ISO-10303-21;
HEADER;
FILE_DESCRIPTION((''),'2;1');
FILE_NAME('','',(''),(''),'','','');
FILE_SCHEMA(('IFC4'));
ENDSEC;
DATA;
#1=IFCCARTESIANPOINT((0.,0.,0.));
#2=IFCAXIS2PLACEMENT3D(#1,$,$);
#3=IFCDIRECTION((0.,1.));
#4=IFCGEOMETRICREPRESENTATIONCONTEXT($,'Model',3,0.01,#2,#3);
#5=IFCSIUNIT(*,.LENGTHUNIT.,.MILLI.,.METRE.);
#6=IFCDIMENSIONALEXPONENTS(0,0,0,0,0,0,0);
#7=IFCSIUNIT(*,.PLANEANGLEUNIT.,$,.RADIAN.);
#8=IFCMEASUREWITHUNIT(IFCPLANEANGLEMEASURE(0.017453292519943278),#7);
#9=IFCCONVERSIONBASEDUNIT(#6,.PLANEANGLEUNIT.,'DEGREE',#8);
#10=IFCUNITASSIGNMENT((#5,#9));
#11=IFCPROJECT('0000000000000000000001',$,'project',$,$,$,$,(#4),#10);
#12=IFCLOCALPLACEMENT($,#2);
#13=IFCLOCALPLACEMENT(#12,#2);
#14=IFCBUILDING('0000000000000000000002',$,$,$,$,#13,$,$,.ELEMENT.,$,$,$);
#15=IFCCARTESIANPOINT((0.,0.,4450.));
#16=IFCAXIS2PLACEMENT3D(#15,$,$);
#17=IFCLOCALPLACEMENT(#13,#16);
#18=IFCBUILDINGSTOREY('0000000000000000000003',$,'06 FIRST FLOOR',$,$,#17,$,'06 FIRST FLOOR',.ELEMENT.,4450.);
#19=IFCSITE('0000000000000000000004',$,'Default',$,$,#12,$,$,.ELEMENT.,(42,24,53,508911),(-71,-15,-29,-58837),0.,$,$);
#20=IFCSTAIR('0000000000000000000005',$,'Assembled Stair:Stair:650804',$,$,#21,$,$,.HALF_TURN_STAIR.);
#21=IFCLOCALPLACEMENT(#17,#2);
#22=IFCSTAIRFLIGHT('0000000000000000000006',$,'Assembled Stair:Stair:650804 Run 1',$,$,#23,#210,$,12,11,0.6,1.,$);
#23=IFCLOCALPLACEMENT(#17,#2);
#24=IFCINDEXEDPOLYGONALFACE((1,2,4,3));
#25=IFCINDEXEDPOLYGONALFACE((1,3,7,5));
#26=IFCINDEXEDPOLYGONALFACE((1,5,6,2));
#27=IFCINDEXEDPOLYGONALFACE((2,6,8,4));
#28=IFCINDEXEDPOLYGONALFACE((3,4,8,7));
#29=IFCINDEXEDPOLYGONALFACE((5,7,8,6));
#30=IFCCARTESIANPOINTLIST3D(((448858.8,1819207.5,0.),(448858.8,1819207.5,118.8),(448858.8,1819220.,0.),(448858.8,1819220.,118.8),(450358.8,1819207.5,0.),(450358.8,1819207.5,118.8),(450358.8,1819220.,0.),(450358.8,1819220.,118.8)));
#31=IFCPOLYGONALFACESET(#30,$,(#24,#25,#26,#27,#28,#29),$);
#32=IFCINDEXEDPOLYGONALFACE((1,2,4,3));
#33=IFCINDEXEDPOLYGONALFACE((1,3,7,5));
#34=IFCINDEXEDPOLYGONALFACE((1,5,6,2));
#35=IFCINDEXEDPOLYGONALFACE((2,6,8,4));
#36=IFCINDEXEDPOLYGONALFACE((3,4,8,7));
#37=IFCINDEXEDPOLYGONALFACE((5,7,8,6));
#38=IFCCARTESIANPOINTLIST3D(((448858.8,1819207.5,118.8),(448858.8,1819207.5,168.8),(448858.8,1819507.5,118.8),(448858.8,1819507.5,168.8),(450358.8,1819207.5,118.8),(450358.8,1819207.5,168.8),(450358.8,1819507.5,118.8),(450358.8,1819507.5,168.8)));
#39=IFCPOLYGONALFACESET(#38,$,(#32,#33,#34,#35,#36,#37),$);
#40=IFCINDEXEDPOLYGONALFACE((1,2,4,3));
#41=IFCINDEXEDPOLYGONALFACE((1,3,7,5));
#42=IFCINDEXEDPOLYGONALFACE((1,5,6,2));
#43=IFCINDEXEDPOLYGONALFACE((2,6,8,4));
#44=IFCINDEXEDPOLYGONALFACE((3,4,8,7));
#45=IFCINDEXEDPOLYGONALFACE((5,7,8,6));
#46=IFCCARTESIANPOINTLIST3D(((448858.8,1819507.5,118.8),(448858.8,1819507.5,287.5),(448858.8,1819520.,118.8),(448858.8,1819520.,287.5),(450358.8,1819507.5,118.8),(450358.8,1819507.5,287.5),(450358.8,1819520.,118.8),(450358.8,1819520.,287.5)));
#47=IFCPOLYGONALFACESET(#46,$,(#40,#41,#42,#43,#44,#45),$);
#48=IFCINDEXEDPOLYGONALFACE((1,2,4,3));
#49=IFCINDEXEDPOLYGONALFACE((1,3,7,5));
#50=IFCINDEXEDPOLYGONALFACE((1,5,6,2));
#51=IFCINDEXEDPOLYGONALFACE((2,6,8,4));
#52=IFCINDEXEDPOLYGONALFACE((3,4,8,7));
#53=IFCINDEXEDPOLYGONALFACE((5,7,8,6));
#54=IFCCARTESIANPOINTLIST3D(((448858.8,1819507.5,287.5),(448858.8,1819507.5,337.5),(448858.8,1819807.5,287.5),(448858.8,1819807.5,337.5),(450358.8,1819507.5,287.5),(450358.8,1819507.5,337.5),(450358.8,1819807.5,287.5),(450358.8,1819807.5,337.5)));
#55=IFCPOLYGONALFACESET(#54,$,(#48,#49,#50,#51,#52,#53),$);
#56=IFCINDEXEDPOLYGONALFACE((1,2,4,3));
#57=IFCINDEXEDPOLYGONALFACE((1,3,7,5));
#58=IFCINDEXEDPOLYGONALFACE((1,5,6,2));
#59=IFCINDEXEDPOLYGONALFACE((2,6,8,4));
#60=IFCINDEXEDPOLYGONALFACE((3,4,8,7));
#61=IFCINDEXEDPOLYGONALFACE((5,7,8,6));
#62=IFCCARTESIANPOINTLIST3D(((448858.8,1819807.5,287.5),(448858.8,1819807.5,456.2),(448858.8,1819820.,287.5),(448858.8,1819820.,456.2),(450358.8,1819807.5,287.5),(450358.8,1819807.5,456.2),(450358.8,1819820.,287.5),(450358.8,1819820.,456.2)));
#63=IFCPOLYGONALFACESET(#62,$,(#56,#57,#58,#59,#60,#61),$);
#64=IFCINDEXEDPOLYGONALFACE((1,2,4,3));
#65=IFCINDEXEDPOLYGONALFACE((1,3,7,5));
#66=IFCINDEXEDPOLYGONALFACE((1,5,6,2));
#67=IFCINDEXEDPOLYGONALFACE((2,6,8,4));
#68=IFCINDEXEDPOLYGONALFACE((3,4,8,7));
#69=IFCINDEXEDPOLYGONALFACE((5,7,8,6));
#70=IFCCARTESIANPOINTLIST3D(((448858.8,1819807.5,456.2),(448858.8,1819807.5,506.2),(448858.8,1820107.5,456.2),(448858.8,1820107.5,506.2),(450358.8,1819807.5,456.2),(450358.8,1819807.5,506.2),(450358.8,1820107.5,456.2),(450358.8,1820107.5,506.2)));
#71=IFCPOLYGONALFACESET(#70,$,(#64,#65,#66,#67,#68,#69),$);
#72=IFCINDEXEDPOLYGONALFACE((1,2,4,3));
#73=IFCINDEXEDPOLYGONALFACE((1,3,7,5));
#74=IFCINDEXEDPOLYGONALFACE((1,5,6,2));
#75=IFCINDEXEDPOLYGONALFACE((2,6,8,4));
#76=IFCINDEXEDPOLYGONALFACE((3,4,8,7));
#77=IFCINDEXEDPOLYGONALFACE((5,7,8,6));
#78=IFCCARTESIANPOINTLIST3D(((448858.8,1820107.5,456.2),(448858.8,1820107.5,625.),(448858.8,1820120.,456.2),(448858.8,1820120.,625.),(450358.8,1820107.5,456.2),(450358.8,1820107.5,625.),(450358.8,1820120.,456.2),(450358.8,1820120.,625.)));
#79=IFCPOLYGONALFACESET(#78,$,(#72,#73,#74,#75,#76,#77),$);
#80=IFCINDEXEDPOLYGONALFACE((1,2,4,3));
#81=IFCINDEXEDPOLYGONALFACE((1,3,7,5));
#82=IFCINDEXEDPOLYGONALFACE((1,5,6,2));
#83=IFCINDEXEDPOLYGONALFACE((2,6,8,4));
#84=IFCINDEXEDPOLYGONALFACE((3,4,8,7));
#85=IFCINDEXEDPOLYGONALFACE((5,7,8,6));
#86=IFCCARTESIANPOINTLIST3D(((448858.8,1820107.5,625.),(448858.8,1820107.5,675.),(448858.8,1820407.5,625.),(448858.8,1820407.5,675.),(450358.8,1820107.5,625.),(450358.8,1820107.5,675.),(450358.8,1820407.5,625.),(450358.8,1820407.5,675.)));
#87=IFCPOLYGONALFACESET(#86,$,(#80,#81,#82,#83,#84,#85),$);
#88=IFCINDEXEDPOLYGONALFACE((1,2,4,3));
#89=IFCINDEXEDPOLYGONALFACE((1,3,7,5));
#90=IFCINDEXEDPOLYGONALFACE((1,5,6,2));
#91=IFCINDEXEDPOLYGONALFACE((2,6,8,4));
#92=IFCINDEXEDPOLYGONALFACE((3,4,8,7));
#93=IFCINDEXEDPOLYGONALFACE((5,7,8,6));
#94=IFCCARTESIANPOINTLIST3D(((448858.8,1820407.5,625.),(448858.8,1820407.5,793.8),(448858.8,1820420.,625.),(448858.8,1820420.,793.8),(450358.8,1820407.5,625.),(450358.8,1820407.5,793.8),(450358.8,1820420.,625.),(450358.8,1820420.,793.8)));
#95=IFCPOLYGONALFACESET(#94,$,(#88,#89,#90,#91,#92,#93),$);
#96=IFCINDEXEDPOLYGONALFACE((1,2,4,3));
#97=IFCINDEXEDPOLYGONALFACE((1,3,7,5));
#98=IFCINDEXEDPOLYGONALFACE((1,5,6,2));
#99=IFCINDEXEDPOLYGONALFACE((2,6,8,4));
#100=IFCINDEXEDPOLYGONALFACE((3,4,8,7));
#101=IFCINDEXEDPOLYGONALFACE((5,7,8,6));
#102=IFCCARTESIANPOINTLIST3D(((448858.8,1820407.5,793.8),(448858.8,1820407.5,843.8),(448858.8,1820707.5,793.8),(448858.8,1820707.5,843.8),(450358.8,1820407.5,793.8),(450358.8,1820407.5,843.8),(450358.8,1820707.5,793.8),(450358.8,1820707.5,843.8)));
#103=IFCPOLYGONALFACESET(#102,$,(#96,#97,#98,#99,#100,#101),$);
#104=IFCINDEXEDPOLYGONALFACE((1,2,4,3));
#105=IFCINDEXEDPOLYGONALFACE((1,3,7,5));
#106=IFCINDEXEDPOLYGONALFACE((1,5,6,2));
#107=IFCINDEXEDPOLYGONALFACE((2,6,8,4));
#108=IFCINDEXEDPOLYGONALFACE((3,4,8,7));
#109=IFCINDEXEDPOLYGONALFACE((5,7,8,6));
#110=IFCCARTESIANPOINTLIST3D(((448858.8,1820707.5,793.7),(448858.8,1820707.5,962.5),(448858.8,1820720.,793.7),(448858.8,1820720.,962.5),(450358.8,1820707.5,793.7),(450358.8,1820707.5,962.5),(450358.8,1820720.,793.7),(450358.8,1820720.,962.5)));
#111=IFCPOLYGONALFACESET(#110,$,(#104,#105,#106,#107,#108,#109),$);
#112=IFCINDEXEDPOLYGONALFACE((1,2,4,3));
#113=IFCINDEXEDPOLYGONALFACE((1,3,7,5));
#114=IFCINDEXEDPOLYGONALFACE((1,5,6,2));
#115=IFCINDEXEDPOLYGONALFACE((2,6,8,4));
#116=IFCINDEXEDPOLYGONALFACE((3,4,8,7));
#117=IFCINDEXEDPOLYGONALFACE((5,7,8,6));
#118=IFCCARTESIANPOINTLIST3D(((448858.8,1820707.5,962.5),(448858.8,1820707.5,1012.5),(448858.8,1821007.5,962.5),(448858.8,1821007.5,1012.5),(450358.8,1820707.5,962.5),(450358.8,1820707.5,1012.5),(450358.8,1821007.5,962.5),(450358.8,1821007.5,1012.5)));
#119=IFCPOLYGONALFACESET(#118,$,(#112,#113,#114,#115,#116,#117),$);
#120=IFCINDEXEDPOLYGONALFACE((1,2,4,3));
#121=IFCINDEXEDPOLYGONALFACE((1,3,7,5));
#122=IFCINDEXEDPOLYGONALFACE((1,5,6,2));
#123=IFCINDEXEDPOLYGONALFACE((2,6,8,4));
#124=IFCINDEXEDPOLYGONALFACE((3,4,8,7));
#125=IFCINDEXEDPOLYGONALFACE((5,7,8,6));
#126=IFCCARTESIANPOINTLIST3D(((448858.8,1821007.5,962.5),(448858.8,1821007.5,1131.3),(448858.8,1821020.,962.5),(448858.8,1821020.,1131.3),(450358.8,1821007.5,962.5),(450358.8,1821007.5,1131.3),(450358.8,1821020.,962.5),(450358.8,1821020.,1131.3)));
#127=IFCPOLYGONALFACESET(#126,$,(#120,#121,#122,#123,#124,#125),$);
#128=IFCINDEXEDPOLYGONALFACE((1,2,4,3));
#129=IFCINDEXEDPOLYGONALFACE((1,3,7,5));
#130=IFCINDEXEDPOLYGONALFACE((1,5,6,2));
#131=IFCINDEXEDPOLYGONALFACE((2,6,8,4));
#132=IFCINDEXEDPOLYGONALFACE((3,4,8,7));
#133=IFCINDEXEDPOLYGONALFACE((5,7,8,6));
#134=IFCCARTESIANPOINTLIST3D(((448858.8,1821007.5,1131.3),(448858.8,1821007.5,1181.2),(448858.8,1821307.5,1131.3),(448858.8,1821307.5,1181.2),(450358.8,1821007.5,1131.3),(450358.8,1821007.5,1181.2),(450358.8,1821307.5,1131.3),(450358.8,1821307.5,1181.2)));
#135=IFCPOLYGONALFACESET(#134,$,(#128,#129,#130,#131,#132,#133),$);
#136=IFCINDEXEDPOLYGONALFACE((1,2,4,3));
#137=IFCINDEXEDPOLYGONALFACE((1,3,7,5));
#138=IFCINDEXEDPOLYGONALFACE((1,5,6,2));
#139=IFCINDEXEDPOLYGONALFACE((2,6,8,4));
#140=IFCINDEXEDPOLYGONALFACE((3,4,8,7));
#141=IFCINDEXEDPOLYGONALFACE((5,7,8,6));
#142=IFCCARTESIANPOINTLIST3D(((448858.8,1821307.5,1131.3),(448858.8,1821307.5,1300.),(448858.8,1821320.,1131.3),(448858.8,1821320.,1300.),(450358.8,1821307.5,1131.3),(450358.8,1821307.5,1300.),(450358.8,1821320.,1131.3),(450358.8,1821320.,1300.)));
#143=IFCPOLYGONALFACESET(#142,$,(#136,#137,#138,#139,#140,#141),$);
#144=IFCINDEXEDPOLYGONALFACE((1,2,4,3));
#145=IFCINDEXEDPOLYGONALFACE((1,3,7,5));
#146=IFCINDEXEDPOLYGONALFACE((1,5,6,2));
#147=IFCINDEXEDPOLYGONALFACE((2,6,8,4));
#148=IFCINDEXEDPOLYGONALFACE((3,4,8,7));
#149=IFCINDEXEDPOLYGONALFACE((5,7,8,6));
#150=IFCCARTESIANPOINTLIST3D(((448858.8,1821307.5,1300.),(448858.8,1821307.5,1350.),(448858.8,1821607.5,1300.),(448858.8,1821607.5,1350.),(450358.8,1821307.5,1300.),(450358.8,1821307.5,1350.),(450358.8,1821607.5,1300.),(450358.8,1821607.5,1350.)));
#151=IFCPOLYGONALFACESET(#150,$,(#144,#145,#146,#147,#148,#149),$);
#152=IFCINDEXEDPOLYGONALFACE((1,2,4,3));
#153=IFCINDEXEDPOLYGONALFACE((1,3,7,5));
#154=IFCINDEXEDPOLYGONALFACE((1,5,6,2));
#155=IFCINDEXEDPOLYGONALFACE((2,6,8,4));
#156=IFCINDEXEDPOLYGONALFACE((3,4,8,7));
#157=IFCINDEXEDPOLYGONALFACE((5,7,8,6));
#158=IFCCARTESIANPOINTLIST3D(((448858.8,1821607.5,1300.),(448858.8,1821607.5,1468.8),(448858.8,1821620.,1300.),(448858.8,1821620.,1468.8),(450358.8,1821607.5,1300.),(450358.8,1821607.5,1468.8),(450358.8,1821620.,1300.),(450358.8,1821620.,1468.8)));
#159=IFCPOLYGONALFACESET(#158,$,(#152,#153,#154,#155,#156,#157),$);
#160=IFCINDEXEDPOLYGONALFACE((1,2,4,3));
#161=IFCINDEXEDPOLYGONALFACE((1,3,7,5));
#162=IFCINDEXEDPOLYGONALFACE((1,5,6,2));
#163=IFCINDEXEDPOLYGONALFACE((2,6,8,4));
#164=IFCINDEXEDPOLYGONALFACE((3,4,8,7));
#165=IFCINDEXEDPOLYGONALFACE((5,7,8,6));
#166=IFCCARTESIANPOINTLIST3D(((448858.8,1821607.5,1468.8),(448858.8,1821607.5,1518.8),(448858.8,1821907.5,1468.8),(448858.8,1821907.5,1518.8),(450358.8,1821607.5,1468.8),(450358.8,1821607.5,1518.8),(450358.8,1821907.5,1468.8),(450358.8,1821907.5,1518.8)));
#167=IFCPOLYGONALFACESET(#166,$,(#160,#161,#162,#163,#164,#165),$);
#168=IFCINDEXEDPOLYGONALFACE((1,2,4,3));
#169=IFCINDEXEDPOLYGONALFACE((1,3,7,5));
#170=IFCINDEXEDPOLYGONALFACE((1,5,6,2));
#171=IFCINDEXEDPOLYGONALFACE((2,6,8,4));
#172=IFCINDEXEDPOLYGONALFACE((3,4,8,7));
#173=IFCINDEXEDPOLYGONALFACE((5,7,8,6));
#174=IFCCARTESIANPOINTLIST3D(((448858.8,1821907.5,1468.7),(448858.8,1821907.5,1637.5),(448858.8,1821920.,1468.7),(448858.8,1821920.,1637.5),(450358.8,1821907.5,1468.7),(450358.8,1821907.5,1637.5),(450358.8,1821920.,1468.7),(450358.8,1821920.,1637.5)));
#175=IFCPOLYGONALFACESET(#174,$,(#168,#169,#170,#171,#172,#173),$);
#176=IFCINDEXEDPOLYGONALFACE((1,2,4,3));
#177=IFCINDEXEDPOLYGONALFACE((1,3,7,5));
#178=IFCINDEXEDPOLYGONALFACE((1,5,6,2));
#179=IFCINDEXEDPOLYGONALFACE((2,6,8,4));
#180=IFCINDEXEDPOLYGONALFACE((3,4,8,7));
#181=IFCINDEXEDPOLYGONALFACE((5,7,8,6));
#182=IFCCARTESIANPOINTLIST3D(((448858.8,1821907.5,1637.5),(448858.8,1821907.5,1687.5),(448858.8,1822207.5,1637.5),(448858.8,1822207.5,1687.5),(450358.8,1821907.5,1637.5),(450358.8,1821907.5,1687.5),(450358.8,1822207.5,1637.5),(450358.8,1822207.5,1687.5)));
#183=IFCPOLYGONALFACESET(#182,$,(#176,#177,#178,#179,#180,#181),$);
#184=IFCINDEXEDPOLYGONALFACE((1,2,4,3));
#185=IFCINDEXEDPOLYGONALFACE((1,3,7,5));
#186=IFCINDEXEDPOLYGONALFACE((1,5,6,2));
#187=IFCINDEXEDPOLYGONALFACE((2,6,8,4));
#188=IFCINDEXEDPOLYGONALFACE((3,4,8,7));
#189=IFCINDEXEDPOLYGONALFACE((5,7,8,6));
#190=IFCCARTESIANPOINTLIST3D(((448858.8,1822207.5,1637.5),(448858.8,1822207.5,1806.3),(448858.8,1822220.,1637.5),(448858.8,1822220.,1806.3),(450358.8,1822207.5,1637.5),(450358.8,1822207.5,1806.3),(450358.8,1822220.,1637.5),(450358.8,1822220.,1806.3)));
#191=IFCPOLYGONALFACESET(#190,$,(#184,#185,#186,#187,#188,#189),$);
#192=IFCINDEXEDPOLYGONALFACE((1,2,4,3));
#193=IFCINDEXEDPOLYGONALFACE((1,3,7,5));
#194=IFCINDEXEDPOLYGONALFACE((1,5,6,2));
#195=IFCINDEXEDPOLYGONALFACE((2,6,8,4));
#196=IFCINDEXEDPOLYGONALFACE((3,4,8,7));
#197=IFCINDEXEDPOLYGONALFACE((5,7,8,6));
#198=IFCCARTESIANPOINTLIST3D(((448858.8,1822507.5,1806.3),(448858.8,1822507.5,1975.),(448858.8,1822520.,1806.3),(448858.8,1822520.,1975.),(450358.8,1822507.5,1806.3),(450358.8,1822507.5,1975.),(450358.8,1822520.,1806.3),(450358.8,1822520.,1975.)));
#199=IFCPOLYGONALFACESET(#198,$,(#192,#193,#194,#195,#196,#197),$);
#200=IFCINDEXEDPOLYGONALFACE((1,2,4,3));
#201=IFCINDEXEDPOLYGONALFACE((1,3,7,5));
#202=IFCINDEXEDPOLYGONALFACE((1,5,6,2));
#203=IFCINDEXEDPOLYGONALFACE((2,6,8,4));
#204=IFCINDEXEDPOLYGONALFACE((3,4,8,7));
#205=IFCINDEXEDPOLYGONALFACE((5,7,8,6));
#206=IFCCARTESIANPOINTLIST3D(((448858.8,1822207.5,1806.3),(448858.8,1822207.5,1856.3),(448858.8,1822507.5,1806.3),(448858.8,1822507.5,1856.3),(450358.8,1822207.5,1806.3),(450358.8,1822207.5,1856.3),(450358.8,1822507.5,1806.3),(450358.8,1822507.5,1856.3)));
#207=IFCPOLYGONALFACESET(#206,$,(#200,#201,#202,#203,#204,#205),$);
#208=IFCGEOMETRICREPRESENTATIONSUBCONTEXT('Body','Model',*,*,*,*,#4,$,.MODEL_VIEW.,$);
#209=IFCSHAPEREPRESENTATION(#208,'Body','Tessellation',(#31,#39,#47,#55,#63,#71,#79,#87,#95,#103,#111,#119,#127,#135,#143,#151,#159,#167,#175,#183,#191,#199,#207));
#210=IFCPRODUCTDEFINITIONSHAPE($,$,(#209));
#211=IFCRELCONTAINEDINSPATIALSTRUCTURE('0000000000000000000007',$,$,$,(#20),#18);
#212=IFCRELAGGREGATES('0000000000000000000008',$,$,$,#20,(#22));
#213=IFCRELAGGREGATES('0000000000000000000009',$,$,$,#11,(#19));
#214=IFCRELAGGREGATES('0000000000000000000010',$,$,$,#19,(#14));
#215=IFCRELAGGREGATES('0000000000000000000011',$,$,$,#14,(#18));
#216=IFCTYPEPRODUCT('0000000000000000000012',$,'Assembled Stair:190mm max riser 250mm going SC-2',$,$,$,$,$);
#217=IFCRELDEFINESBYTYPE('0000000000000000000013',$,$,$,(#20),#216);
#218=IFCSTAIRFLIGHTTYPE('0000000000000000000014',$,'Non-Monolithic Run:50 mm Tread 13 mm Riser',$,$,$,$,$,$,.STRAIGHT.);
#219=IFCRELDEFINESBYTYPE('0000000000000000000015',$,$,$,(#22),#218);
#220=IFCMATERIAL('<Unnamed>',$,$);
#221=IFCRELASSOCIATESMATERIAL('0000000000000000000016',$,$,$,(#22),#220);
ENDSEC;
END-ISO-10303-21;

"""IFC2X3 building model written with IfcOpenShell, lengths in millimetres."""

from ifc_helpers import new_model, entity, si_unit, converted_unit, direction, frame, frame_2d, origin, origin_2d_with_axis, place, context, subcontext, project, spatial, rectangle, extrude, material, type_object, element, aggregate, save


model = new_model("IFC2X3")

# Units and contexts
model_context = context("Model", 3, precision=0.01, world=origin(), true_north=direction((0.0, 1.0)))
body_context = subcontext(model_context, "Body", "Model", "MODEL_VIEW")
ifc_project = project(units=[si_unit("LENGTHUNIT", "METRE", prefix="MILLI"), converted_unit("PLANEANGLEUNIT", "DEGREE", entity("IfcPlaneAngleMeasure", 0.017453292519943278), si_unit("PLANEANGLEUNIT", "RADIAN"), dimensions=[0, 0, 0, 0, 0, 0, 0])], contexts=[model_context])

# Site, building, storey
site_placement = place(None, origin())
site = spatial("IfcSite", under=ifc_project, at=site_placement, Name="Default", CompositionType="ELEMENT", RefLatitude=(42, 24, 53, 508911), RefLongitude=(-71, -15, -29, -58837), RefElevation=0.0)
building_placement = place(site_placement, origin())
building = spatial("IfcBuilding", under=site, at=building_placement, CompositionType="ELEMENT")
storey_placement = place(building_placement, frame((0.0, 0.0, 4450.0)))
storey = spatial("IfcBuildingStorey", under=building, at=storey_placement, Name="06 FIRST FLOOR", LongName="06 FIRST FLOOR", CompositionType="ELEMENT", Elevation=4450.0)

# Stair
ifc_material_1 = material(Name="<Unnamed>")
type_product_1 = type_object("IfcTypeProduct", Name="Assembled Stair:190mm max riser 250mm going SC-2")
stair_1_placement = place(storey_placement, origin())
stair_1 = element("IfcStair", 1, at=stair_1_placement, inside=storey, type_object=type_product_1, Name="Assembled Stair:Stair:650804", ShapeType="HALF_TURN_STAIR")

# Stair flight
stair_flight_type = type_object("IfcStairFlightType", Name="Non-Monolithic Run:50 mm Tread 13 mm Riser", PredefinedType="STRAIGHT")
stair_flight_1_placement = place(stair_1_placement, origin())
stair_flight_1 = element("IfcStairFlight", 2, at=stair_flight_1_placement, type_object=stair_flight_type, material=ifc_material_1, Name="Assembled Stair:Stair:650804 Run 1", NumberOfRiser=12, NumberOfTreads=11, RiserHeight=0.6, TreadLength=1.0, context=body_context, shape_type="SweptSolid", body=[
    extrude(rectangle(XDim=1500.0, YDim=12.5, at=origin_2d_with_axis()), frame((449608.8, 1819213.8, 0.0), z_axis=(0.0, 0.0, 1.0), x_axis=(-1.0, 0.0, 0.0)), (0.0, 0.0, 1.0), 118.8),
    extrude(rectangle(XDim=300.0, YDim=1500.0, at=frame_2d((0.0, 0.0), x_axis=(1.0, 0.0))), frame((449608.8, 1819357.5, 118.8), z_axis=(0.0, 0.0, 1.0), x_axis=(0.0, -1.0, 0.0)), (0.0, 0.0, 1.0), 50.0),
    extrude(rectangle(XDim=1500.0, YDim=12.5, at=origin_2d_with_axis()), frame((449608.8, 1819513.8, 118.8), z_axis=(0.0, 0.0, 1.0), x_axis=(-1.0, 0.0, 0.0)), (0.0, 0.0, 1.0), 168.8),
    extrude(rectangle(XDim=300.0, YDim=1500.0, at=origin_2d_with_axis()), frame((449608.8, 1819657.5, 287.5), z_axis=(0.0, 0.0, 1.0), x_axis=(0.0, -1.0, 0.0)), (0.0, 0.0, 1.0), 50.0),
    extrude(rectangle(XDim=1500.0, YDim=12.5, at=origin_2d_with_axis()), frame((449608.8, 1819813.8, 287.5), z_axis=(0.0, 0.0, 1.0), x_axis=(-1.0, 0.0, 0.0)), (0.0, 0.0, 1.0), 168.8),
    extrude(rectangle(XDim=300.0, YDim=1500.0, at=origin_2d_with_axis()), frame((449608.8, 1819957.5, 456.3), z_axis=(0.0, 0.0, 1.0), x_axis=(0.0, -1.0, 0.0)), (0.0, 0.0, 1.0), 50.0),
    extrude(rectangle(XDim=1500.0, YDim=12.5, at=origin_2d_with_axis()), frame((449608.8, 1820113.8, 456.3), z_axis=(0.0, 0.0, 1.0), x_axis=(-1.0, 0.0, 0.0)), (0.0, 0.0, 1.0), 168.8),
    extrude(rectangle(XDim=300.0, YDim=1500.0, at=origin_2d_with_axis()), frame((449608.8, 1820257.5, 625.0), z_axis=(0.0, 0.0, 1.0), x_axis=(0.0, -1.0, 0.0)), (0.0, 0.0, 1.0), 50.0),
    extrude(rectangle(XDim=1500.0, YDim=12.5, at=origin_2d_with_axis()), frame((449608.8, 1820413.8, 625.0), z_axis=(0.0, 0.0, 1.0), x_axis=(-1.0, 0.0, 0.0)), (0.0, 0.0, 1.0), 168.8),
    extrude(rectangle(XDim=300.0, YDim=1500.0, at=origin_2d_with_axis()), frame((449608.8, 1820557.5, 793.8), z_axis=(0.0, 0.0, 1.0), x_axis=(0.0, -1.0, 0.0)), (0.0, 0.0, 1.0), 50.0),
    extrude(rectangle(XDim=1500.0, YDim=12.5, at=origin_2d_with_axis()), frame((449608.8, 1820713.8, 793.7), z_axis=(0.0, 0.0, 1.0), x_axis=(-1.0, 0.0, 0.0)), (0.0, 0.0, 1.0), 168.8),
    extrude(rectangle(XDim=300.0, YDim=1500.0, at=origin_2d_with_axis()), frame((449608.8, 1820857.5, 962.5), z_axis=(0.0, 0.0, 1.0), x_axis=(0.0, -1.0, 0.0)), (0.0, 0.0, 1.0), 50.0),
    extrude(rectangle(XDim=1500.0, YDim=12.5, at=origin_2d_with_axis()), frame((449608.8, 1821013.8, 962.5), z_axis=(0.0, 0.0, 1.0), x_axis=(-1.0, 0.0, 0.0)), (0.0, 0.0, 1.0), 168.8),
    extrude(rectangle(XDim=300.0, YDim=1500.0, at=origin_2d_with_axis()), frame((449608.8, 1821157.5, 1131.3), z_axis=(0.0, 0.0, 1.0), x_axis=(0.0, -1.0, 0.0)), (0.0, 0.0, 1.0), 50.0),
    extrude(rectangle(XDim=1500.0, YDim=12.5, at=origin_2d_with_axis()), frame((449608.8, 1821313.8, 1131.3), z_axis=(0.0, 0.0, 1.0), x_axis=(-1.0, 0.0, 0.0)), (0.0, 0.0, 1.0), 168.8),
    extrude(rectangle(XDim=300.0, YDim=1500.0, at=origin_2d_with_axis()), frame((449608.8, 1821457.5, 1300.0), z_axis=(0.0, 0.0, 1.0), x_axis=(0.0, -1.0, 0.0)), (0.0, 0.0, 1.0), 50.0),
    extrude(rectangle(XDim=1500.0, YDim=12.5, at=origin_2d_with_axis()), frame((449608.8, 1821613.8, 1300.0), z_axis=(0.0, 0.0, 1.0), x_axis=(-1.0, 0.0, 0.0)), (0.0, 0.0, 1.0), 168.8),
    extrude(rectangle(XDim=300.0, YDim=1500.0, at=origin_2d_with_axis()), frame((449608.8, 1821757.5, 1468.8), z_axis=(0.0, 0.0, 1.0), x_axis=(0.0, -1.0, 0.0)), (0.0, 0.0, 1.0), 50.0),
    extrude(rectangle(XDim=1500.0, YDim=12.5, at=origin_2d_with_axis()), frame((449608.8, 1821913.8, 1468.7), z_axis=(0.0, 0.0, 1.0), x_axis=(-1.0, 0.0, 0.0)), (0.0, 0.0, 1.0), 168.8),
    extrude(rectangle(XDim=300.0, YDim=1500.0, at=origin_2d_with_axis()), frame((449608.8, 1822057.5, 1637.5), z_axis=(0.0, 0.0, 1.0), x_axis=(0.0, -1.0, 0.0)), (0.0, 0.0, 1.0), 50.0),
    extrude(rectangle(XDim=1500.0, YDim=12.5, at=origin_2d_with_axis()), frame((449608.8, 1822213.8, 1637.5), z_axis=(0.0, 0.0, 1.0), x_axis=(-1.0, 0.0, 0.0)), (0.0, 0.0, 1.0), 168.8),
    extrude(rectangle(XDim=1500.0, YDim=12.5, at=origin_2d_with_axis()), frame((449608.8, 1822513.8, 1806.3), z_axis=(0.0, 0.0, 1.0), x_axis=(-1.0, 0.0, 0.0)), (0.0, 0.0, 1.0), 168.7),
    extrude(rectangle(XDim=300.0, YDim=1500.0, at=origin_2d_with_axis()), frame((449608.8, 1822357.5, 1806.3), z_axis=(0.0, 0.0, 1.0), x_axis=(0.0, -1.0, 0.0)), (0.0, 0.0, 1.0), 50.0),
])

aggregate(stair_1, [stair_flight_1])

save(model, "model.ifc")
